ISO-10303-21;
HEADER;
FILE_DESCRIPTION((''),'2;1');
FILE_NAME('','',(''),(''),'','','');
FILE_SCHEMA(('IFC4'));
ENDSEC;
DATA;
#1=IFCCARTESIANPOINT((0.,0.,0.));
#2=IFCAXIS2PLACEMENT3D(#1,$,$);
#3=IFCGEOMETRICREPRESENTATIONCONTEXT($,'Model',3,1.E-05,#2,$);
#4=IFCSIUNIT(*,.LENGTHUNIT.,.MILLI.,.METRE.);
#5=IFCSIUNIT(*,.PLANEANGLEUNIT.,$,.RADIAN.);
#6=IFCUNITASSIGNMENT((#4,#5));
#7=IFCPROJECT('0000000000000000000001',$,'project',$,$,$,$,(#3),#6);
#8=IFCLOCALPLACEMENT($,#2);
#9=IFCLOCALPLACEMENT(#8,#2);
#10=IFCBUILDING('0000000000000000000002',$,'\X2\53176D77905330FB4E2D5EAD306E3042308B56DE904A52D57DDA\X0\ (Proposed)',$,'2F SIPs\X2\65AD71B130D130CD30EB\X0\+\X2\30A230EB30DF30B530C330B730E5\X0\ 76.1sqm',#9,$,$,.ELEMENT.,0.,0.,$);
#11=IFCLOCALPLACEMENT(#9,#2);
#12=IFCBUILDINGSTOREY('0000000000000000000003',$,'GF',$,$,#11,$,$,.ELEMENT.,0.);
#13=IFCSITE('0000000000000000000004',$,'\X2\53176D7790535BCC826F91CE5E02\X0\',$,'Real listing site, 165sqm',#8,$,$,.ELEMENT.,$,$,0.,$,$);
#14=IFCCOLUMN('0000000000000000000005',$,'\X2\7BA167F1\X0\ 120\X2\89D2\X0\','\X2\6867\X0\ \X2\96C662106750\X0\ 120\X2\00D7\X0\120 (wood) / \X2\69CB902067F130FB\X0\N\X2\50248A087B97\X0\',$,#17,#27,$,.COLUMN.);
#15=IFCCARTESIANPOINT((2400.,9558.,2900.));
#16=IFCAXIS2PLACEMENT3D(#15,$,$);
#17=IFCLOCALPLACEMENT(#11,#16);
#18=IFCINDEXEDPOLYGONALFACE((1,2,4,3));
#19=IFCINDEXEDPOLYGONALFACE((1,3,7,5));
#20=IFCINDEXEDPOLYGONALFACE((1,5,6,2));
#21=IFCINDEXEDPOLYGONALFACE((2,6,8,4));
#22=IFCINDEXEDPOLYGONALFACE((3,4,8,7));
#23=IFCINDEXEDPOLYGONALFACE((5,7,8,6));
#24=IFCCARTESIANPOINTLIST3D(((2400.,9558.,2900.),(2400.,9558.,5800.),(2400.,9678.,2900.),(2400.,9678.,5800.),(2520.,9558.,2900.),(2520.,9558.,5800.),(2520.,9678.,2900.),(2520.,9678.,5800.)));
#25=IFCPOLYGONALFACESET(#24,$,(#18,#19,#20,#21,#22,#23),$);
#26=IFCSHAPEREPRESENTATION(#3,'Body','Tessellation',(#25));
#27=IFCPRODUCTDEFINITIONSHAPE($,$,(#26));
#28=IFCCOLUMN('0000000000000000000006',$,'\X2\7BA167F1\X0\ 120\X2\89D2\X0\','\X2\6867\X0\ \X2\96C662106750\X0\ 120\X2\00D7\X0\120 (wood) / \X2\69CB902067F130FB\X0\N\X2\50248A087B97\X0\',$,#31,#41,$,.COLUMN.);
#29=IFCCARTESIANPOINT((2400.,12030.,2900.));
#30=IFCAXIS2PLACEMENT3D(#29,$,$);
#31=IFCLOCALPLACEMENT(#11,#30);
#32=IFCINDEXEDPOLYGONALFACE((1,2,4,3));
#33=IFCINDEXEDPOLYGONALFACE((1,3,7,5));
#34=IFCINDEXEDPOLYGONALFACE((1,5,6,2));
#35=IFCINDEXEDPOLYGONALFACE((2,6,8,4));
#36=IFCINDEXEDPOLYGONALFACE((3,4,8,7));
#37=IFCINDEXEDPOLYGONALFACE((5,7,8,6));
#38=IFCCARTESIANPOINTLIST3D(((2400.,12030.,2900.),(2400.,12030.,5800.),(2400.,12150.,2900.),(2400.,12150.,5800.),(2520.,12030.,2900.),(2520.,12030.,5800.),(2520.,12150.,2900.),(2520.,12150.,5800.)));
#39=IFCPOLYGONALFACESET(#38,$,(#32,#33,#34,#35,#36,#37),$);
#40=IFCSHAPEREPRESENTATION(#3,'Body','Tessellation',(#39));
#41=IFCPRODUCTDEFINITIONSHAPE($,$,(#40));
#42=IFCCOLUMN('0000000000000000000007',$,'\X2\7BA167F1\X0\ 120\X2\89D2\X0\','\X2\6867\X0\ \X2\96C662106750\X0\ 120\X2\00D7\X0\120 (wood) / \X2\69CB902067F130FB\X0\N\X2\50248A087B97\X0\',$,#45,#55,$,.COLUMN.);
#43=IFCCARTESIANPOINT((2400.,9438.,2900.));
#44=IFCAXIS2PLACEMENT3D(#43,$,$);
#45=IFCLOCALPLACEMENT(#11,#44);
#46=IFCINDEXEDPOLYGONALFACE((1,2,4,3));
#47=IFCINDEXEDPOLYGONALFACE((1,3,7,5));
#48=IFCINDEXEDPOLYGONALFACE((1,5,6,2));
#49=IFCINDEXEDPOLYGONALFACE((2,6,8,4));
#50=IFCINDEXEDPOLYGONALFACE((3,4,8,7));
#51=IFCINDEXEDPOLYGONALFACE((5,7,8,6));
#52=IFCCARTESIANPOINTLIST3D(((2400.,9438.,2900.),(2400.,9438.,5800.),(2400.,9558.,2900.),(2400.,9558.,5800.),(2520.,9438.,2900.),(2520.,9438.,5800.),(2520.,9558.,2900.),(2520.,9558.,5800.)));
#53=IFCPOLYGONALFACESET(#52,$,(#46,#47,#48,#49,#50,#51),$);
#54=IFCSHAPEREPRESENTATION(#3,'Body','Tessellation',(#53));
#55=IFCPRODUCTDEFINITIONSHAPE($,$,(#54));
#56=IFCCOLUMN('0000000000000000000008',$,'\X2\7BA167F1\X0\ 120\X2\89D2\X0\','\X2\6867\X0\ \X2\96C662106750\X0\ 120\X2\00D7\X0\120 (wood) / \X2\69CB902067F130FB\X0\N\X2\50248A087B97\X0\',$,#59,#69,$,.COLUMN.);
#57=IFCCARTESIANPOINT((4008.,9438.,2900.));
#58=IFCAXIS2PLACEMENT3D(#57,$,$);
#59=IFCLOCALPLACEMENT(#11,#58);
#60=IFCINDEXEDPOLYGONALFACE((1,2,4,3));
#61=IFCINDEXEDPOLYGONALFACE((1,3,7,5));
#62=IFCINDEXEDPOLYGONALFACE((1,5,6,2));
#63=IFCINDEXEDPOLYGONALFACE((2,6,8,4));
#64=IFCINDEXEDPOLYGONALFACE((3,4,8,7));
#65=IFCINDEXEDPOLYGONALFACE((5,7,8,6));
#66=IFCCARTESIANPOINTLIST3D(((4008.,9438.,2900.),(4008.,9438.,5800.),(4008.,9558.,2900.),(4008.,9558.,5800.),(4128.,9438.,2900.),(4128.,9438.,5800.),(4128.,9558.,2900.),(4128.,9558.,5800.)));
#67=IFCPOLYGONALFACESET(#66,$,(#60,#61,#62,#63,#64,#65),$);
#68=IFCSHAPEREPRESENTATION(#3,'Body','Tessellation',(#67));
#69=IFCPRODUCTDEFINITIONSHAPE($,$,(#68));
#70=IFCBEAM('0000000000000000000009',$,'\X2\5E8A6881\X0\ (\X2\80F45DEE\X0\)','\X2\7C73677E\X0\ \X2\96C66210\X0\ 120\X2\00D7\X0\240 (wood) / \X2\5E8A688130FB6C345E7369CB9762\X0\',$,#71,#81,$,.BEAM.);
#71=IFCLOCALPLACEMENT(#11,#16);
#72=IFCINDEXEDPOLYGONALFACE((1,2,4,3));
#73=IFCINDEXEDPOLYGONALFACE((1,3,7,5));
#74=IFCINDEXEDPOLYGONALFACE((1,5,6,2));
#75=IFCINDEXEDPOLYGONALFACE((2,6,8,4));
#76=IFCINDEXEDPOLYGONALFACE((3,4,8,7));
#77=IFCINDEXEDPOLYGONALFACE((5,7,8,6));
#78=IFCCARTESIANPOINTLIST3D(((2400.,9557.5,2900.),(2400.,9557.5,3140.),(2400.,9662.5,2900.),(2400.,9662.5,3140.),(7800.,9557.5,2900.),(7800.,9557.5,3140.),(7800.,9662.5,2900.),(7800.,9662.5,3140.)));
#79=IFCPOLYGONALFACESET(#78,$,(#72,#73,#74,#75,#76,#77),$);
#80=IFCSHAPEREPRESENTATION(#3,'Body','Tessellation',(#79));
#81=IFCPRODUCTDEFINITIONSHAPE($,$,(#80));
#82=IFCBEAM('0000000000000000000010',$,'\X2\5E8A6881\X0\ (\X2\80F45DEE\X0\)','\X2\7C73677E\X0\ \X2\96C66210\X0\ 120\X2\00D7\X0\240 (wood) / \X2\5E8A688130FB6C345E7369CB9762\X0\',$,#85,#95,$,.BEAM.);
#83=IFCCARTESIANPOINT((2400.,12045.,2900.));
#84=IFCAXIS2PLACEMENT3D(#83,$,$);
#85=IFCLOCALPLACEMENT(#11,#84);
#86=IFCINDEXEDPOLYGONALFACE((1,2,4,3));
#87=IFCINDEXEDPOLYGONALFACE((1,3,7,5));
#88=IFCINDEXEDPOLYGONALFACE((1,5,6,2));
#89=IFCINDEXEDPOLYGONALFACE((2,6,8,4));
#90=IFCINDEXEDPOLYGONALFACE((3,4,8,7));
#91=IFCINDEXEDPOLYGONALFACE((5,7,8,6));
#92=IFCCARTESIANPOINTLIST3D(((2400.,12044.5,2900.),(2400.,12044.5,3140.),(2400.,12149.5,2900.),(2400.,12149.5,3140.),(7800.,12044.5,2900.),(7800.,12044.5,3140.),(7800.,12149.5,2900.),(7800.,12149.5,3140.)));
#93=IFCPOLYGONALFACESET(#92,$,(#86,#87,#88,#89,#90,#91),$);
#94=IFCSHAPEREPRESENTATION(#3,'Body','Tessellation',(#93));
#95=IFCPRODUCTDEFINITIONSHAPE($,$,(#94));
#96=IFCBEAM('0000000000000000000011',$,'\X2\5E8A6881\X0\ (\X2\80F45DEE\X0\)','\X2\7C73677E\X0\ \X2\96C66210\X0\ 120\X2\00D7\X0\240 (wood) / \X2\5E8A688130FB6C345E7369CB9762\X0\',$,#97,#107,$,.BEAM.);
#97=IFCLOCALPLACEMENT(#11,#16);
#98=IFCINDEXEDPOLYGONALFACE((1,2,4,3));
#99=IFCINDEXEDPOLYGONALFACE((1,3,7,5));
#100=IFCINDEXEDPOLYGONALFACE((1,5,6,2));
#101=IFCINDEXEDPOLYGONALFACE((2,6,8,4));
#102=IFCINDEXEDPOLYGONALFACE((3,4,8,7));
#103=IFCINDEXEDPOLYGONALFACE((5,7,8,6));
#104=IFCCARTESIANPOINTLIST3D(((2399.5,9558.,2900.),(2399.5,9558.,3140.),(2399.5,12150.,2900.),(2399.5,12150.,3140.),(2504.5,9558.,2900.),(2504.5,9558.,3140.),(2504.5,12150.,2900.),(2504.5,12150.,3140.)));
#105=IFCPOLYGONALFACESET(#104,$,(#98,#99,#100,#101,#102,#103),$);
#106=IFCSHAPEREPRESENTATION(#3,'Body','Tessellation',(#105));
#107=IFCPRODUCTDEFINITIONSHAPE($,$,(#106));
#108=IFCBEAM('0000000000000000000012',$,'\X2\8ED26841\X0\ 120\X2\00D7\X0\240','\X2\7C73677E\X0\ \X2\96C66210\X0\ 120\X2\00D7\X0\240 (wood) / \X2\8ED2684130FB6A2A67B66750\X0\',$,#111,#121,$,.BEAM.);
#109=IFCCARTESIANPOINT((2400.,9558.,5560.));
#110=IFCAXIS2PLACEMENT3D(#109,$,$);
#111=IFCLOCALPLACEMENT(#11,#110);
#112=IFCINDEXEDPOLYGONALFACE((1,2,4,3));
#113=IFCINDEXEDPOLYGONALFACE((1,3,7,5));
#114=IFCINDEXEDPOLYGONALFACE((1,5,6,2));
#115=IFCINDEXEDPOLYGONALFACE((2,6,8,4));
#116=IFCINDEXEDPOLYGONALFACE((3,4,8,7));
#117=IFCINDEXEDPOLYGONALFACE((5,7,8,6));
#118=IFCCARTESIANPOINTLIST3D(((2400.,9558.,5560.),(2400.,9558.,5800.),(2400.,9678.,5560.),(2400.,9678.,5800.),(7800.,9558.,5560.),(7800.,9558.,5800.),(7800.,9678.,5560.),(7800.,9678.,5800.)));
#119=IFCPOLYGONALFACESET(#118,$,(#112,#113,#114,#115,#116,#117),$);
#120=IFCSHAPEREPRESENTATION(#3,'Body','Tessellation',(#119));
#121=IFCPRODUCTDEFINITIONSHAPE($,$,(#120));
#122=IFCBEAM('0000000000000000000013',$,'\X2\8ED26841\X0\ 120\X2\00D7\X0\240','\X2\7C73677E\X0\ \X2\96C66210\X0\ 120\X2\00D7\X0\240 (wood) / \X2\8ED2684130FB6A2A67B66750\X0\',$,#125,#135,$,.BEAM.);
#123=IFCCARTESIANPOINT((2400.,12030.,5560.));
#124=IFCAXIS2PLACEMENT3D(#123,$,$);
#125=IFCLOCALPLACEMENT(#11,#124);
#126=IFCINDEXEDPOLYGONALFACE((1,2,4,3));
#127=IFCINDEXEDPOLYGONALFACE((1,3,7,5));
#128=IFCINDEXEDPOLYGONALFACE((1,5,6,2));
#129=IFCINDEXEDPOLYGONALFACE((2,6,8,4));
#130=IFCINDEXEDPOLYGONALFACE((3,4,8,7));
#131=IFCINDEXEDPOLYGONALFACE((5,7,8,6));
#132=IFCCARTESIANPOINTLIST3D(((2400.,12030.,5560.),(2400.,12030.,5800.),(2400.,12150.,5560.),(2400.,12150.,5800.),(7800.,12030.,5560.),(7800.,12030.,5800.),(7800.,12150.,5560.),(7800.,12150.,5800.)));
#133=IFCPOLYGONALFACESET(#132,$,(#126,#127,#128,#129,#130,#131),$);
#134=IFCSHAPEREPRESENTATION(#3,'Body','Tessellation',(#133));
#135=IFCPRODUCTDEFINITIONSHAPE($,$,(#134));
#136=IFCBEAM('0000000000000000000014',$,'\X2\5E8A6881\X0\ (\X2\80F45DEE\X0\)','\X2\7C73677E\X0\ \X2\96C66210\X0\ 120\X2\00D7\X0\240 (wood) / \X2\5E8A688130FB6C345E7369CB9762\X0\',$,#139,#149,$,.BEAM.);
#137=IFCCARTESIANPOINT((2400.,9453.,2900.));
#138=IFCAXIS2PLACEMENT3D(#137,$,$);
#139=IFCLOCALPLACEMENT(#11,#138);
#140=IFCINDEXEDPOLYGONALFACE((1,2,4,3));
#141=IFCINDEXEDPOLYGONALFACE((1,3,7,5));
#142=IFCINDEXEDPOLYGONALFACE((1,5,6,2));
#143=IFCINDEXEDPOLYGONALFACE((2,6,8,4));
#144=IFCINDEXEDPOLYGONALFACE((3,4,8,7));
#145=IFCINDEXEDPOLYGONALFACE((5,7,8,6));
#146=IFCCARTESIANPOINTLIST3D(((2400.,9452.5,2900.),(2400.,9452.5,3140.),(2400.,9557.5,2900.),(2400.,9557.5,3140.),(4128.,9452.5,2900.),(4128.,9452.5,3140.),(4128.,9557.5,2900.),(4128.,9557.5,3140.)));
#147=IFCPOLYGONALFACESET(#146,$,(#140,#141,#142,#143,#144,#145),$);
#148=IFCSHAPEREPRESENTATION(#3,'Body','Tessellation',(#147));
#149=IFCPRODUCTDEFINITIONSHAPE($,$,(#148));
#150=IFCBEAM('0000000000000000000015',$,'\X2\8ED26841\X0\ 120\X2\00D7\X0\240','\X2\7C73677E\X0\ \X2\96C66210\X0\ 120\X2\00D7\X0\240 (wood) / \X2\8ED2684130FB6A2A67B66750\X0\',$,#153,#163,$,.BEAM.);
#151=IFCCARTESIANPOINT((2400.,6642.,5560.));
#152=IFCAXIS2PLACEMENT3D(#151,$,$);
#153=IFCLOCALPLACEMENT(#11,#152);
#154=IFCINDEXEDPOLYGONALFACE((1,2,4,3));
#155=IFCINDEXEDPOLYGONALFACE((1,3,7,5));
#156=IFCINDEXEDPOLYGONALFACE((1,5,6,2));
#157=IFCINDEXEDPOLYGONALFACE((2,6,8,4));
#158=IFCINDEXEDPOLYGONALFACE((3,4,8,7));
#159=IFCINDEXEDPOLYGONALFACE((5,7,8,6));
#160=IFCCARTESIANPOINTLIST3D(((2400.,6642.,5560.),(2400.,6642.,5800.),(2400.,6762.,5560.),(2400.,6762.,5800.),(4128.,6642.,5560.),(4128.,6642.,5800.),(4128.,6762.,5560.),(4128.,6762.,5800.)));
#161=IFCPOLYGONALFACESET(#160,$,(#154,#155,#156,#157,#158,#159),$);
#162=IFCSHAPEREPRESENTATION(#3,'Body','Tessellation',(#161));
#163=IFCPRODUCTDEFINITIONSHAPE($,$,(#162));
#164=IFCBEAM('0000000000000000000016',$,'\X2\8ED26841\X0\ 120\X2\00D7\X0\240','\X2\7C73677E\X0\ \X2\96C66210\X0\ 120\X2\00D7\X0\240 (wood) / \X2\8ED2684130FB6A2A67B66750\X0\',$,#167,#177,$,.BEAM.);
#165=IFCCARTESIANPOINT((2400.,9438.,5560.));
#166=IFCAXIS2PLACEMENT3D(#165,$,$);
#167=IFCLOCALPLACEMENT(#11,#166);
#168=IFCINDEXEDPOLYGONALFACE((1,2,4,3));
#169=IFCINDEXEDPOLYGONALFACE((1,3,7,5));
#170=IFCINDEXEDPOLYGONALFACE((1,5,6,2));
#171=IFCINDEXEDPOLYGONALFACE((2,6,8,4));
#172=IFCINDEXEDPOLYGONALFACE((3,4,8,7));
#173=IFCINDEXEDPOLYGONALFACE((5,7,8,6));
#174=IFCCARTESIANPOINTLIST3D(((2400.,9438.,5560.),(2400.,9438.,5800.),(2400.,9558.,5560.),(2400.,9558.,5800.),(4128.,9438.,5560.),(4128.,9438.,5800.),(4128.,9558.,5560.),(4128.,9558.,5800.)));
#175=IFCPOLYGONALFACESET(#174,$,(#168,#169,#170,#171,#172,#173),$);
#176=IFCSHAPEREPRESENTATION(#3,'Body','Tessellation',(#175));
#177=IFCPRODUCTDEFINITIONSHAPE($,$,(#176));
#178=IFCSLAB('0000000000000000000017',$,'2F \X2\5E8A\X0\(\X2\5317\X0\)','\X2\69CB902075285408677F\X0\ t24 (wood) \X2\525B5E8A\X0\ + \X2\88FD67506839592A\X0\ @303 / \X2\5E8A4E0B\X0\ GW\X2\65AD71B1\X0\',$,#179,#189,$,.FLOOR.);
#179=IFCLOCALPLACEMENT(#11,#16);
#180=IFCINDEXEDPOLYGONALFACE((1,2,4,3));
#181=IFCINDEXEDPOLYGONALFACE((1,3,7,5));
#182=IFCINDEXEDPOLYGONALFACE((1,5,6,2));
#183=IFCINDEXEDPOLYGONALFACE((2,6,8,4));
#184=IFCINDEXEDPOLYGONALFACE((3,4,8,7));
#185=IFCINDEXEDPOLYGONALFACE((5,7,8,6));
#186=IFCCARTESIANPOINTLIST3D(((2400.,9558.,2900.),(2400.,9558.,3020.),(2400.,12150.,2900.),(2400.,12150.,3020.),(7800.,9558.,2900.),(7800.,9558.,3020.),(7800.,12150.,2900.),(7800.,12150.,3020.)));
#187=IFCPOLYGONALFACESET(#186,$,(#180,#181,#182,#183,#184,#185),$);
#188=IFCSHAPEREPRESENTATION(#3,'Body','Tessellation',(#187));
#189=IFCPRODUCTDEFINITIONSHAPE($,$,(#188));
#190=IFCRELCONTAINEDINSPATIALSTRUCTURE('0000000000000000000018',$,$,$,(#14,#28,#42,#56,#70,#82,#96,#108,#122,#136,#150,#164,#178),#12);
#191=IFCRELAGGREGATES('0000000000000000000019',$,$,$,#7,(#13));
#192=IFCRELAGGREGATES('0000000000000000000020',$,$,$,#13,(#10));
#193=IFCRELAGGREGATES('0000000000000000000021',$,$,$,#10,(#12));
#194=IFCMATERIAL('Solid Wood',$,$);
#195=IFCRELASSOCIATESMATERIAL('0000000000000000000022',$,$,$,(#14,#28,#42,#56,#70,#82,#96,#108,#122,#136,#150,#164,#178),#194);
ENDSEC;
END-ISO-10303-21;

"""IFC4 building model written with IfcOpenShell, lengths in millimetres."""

from ifc_helpers import new_model, si_unit, frame, frame_2d, origin, place, context, project, spatial, rectangle, extrude, material, element, save


model = new_model("IFC4")

# Units and contexts
model_context = context("Model", 3, precision=1e-05, world=origin())
ifc_project = project(units=[si_unit("LENGTHUNIT", "METRE", prefix="MILLI"), si_unit("PLANEANGLEUNIT", "RADIAN")], contexts=[model_context])

# Site, building, storey
site_placement = place(None, origin())
site = spatial("IfcSite", under=ifc_project, at=site_placement, Name="北海道富良野市", ObjectType="Real listing site, 165sqm", CompositionType="ELEMENT", RefElevation=0.0)
building_placement = place(site_placement, origin())
building = spatial("IfcBuilding", under=site, at=building_placement, Name="北海道・中庭のある回遊動線 (Proposed)", ObjectType="2F SIPs断熱パネル+アルミサッシュ 76.1sqm", CompositionType="ELEMENT", ElevationOfRefHeight=0.0, ElevationOfTerrain=0.0)
storey_placement = place(building_placement, origin())
storey = spatial("IfcBuildingStorey", under=building, at=storey_placement, Name="GF", CompositionType="ELEMENT", Elevation=0.0)

# Columns
ifc_material_1 = material(Name="Solid Wood")
column_1_placement = place(storey_placement, frame((2400.0, 9558.0, 2900.0)))
element("IfcColumn", 1, at=column_1_placement, inside=storey, material=ifc_material_1, Name="管柱 120角", Description="桧 集成材 120×120 (wood) / 構造柱・N値計算", PredefinedType="COLUMN", context=model_context, shape_type="SweptSolid", body=[
    extrude(rectangle(XDim=120.0, YDim=120.0, at=frame_2d((60.0, 60.0))), frame((2400.0, 9558.0, 2900.0)), (0.0, 0.0, 1.0), 2900.0),
])
column_2_placement = place(storey_placement, frame((2400.0, 12030.0, 2900.0)))
element("IfcColumn", 2, at=column_2_placement, inside=storey, material=ifc_material_1, Name="管柱 120角", Description="桧 集成材 120×120 (wood) / 構造柱・N値計算", PredefinedType="COLUMN", context=model_context, shape_type="SweptSolid", body=[
    extrude(rectangle(XDim=120.0, YDim=120.0, at=frame_2d((60.0, 60.0))), frame((2400.0, 12030.0, 2900.0)), (0.0, 0.0, 1.0), 2900.0),
])
column_3_placement = place(storey_placement, frame((2400.0, 9438.0, 2900.0)))
element("IfcColumn", 3, at=column_3_placement, inside=storey, material=ifc_material_1, Name="管柱 120角", Description="桧 集成材 120×120 (wood) / 構造柱・N値計算", PredefinedType="COLUMN", context=model_context, shape_type="SweptSolid", body=[
    extrude(rectangle(XDim=120.0, YDim=120.0, at=frame_2d((60.0, 60.0))), frame((2400.0, 9438.0, 2900.0)), (0.0, 0.0, 1.0), 2900.0),
])
column_4_placement = place(storey_placement, frame((4008.0, 9438.0, 2900.0)))
element("IfcColumn", 4, at=column_4_placement, inside=storey, material=ifc_material_1, Name="管柱 120角", Description="桧 集成材 120×120 (wood) / 構造柱・N値計算", PredefinedType="COLUMN", context=model_context, shape_type="SweptSolid", body=[
    extrude(rectangle(XDim=120.0, YDim=120.0, at=frame_2d((60.0, 60.0))), frame((4008.0, 9438.0, 2900.0)), (0.0, 0.0, 1.0), 2900.0),
])

# Beams
beam_1_placement = place(storey_placement, frame((2400.0, 9558.0, 2900.0)))
element("IfcBeam", 5, at=beam_1_placement, inside=storey, material=ifc_material_1, Name="床梁 (胴差)", Description="米松 集成 120×240 (wood) / 床梁・水平構面", PredefinedType="BEAM", context=model_context, shape_type="SweptSolid", body=[
    extrude(rectangle(XDim=5400.0, YDim=105.0, at=frame_2d((2700.0, 52.0))), frame((2400.0, 9558.0, 2900.0)), (0.0, 0.0, 1.0), 240.0),
])
beam_2_placement = place(storey_placement, frame((2400.0, 12045.0, 2900.0)))
element("IfcBeam", 6, at=beam_2_placement, inside=storey, material=ifc_material_1, Name="床梁 (胴差)", Description="米松 集成 120×240 (wood) / 床梁・水平構面", PredefinedType="BEAM", context=model_context, shape_type="SweptSolid", body=[
    extrude(rectangle(XDim=5400.0, YDim=105.0, at=frame_2d((2700.0, 52.0))), frame((2400.0, 12045.0, 2900.0)), (0.0, 0.0, 1.0), 240.0),
])
beam_3_placement = place(storey_placement, frame((2400.0, 9558.0, 2900.0)))
element("IfcBeam", 7, at=beam_3_placement, inside=storey, material=ifc_material_1, Name="床梁 (胴差)", Description="米松 集成 120×240 (wood) / 床梁・水平構面", PredefinedType="BEAM", context=model_context, shape_type="SweptSolid", body=[
    extrude(rectangle(XDim=105.0, YDim=2592.0, at=frame_2d((52.0, 1296.0))), frame((2400.0, 9558.0, 2900.0)), (0.0, 0.0, 1.0), 240.0),
])
beam_4_placement = place(storey_placement, frame((2400.0, 9558.0, 5560.0)))
element("IfcBeam", 8, at=beam_4_placement, inside=storey, material=ifc_material_1, Name="軒桁 120×240", Description="米松 集成 120×240 (wood) / 軒桁・横架材", PredefinedType="BEAM", context=model_context, shape_type="SweptSolid", body=[
    extrude(rectangle(XDim=5400.0, YDim=120.0, at=frame_2d((2700.0, 60.0))), frame((2400.0, 9558.0, 5560.0)), (0.0, 0.0, 1.0), 240.0),
])
beam_5_placement = place(storey_placement, frame((2400.0, 12030.0, 5560.0)))
element("IfcBeam", 9, at=beam_5_placement, inside=storey, material=ifc_material_1, Name="軒桁 120×240", Description="米松 集成 120×240 (wood) / 軒桁・横架材", PredefinedType="BEAM", context=model_context, shape_type="SweptSolid", body=[
    extrude(rectangle(XDim=5400.0, YDim=120.0, at=frame_2d((2700.0, 60.0))), frame((2400.0, 12030.0, 5560.0)), (0.0, 0.0, 1.0), 240.0),
])
beam_6_placement = place(storey_placement, frame((2400.0, 9453.0, 2900.0)))
element("IfcBeam", 10, at=beam_6_placement, inside=storey, material=ifc_material_1, Name="床梁 (胴差)", Description="米松 集成 120×240 (wood) / 床梁・水平構面", PredefinedType="BEAM", context=model_context, shape_type="SweptSolid", body=[
    extrude(rectangle(XDim=1728.0, YDim=105.0, at=frame_2d((864.0, 52.0))), frame((2400.0, 9453.0, 2900.0)), (0.0, 0.0, 1.0), 240.0),
])
beam_7_placement = place(storey_placement, frame((2400.0, 6642.0, 5560.0)))
element("IfcBeam", 11, at=beam_7_placement, inside=storey, material=ifc_material_1, Name="軒桁 120×240", Description="米松 集成 120×240 (wood) / 軒桁・横架材", PredefinedType="BEAM", context=model_context, shape_type="SweptSolid", body=[
    extrude(rectangle(XDim=1728.0, YDim=120.0, at=frame_2d((864.0, 60.0))), frame((2400.0, 6642.0, 5560.0)), (0.0, 0.0, 1.0), 240.0),
])
beam_8_placement = place(storey_placement, frame((2400.0, 9438.0, 5560.0)))
element("IfcBeam", 12, at=beam_8_placement, inside=storey, material=ifc_material_1, Name="軒桁 120×240", Description="米松 集成 120×240 (wood) / 軒桁・横架材", PredefinedType="BEAM", context=model_context, shape_type="SweptSolid", body=[
    extrude(rectangle(XDim=1728.0, YDim=120.0, at=frame_2d((864.0, 60.0))), frame((2400.0, 9438.0, 5560.0)), (0.0, 0.0, 1.0), 240.0),
])

# Slab
slab_placement = place(storey_placement, frame((2400.0, 9558.0, 2900.0)))
element("IfcSlab", 13, at=slab_placement, inside=storey, material=ifc_material_1, Name="2F 床(北)", Description="構造用合板 t24 (wood) 剛床 + 製材根太 @303 / 床下 GW断熱", PredefinedType="FLOOR", context=model_context, shape_type="SweptSolid", body=[
    extrude(rectangle(XDim=5400.0, YDim=2592.0, at=frame_2d((2700.0, 1296.0))), frame((2400.0, 9558.0, 2900.0)), (0.0, 0.0, 1.0), 120.0),
])

save(model, "model.ifc")
